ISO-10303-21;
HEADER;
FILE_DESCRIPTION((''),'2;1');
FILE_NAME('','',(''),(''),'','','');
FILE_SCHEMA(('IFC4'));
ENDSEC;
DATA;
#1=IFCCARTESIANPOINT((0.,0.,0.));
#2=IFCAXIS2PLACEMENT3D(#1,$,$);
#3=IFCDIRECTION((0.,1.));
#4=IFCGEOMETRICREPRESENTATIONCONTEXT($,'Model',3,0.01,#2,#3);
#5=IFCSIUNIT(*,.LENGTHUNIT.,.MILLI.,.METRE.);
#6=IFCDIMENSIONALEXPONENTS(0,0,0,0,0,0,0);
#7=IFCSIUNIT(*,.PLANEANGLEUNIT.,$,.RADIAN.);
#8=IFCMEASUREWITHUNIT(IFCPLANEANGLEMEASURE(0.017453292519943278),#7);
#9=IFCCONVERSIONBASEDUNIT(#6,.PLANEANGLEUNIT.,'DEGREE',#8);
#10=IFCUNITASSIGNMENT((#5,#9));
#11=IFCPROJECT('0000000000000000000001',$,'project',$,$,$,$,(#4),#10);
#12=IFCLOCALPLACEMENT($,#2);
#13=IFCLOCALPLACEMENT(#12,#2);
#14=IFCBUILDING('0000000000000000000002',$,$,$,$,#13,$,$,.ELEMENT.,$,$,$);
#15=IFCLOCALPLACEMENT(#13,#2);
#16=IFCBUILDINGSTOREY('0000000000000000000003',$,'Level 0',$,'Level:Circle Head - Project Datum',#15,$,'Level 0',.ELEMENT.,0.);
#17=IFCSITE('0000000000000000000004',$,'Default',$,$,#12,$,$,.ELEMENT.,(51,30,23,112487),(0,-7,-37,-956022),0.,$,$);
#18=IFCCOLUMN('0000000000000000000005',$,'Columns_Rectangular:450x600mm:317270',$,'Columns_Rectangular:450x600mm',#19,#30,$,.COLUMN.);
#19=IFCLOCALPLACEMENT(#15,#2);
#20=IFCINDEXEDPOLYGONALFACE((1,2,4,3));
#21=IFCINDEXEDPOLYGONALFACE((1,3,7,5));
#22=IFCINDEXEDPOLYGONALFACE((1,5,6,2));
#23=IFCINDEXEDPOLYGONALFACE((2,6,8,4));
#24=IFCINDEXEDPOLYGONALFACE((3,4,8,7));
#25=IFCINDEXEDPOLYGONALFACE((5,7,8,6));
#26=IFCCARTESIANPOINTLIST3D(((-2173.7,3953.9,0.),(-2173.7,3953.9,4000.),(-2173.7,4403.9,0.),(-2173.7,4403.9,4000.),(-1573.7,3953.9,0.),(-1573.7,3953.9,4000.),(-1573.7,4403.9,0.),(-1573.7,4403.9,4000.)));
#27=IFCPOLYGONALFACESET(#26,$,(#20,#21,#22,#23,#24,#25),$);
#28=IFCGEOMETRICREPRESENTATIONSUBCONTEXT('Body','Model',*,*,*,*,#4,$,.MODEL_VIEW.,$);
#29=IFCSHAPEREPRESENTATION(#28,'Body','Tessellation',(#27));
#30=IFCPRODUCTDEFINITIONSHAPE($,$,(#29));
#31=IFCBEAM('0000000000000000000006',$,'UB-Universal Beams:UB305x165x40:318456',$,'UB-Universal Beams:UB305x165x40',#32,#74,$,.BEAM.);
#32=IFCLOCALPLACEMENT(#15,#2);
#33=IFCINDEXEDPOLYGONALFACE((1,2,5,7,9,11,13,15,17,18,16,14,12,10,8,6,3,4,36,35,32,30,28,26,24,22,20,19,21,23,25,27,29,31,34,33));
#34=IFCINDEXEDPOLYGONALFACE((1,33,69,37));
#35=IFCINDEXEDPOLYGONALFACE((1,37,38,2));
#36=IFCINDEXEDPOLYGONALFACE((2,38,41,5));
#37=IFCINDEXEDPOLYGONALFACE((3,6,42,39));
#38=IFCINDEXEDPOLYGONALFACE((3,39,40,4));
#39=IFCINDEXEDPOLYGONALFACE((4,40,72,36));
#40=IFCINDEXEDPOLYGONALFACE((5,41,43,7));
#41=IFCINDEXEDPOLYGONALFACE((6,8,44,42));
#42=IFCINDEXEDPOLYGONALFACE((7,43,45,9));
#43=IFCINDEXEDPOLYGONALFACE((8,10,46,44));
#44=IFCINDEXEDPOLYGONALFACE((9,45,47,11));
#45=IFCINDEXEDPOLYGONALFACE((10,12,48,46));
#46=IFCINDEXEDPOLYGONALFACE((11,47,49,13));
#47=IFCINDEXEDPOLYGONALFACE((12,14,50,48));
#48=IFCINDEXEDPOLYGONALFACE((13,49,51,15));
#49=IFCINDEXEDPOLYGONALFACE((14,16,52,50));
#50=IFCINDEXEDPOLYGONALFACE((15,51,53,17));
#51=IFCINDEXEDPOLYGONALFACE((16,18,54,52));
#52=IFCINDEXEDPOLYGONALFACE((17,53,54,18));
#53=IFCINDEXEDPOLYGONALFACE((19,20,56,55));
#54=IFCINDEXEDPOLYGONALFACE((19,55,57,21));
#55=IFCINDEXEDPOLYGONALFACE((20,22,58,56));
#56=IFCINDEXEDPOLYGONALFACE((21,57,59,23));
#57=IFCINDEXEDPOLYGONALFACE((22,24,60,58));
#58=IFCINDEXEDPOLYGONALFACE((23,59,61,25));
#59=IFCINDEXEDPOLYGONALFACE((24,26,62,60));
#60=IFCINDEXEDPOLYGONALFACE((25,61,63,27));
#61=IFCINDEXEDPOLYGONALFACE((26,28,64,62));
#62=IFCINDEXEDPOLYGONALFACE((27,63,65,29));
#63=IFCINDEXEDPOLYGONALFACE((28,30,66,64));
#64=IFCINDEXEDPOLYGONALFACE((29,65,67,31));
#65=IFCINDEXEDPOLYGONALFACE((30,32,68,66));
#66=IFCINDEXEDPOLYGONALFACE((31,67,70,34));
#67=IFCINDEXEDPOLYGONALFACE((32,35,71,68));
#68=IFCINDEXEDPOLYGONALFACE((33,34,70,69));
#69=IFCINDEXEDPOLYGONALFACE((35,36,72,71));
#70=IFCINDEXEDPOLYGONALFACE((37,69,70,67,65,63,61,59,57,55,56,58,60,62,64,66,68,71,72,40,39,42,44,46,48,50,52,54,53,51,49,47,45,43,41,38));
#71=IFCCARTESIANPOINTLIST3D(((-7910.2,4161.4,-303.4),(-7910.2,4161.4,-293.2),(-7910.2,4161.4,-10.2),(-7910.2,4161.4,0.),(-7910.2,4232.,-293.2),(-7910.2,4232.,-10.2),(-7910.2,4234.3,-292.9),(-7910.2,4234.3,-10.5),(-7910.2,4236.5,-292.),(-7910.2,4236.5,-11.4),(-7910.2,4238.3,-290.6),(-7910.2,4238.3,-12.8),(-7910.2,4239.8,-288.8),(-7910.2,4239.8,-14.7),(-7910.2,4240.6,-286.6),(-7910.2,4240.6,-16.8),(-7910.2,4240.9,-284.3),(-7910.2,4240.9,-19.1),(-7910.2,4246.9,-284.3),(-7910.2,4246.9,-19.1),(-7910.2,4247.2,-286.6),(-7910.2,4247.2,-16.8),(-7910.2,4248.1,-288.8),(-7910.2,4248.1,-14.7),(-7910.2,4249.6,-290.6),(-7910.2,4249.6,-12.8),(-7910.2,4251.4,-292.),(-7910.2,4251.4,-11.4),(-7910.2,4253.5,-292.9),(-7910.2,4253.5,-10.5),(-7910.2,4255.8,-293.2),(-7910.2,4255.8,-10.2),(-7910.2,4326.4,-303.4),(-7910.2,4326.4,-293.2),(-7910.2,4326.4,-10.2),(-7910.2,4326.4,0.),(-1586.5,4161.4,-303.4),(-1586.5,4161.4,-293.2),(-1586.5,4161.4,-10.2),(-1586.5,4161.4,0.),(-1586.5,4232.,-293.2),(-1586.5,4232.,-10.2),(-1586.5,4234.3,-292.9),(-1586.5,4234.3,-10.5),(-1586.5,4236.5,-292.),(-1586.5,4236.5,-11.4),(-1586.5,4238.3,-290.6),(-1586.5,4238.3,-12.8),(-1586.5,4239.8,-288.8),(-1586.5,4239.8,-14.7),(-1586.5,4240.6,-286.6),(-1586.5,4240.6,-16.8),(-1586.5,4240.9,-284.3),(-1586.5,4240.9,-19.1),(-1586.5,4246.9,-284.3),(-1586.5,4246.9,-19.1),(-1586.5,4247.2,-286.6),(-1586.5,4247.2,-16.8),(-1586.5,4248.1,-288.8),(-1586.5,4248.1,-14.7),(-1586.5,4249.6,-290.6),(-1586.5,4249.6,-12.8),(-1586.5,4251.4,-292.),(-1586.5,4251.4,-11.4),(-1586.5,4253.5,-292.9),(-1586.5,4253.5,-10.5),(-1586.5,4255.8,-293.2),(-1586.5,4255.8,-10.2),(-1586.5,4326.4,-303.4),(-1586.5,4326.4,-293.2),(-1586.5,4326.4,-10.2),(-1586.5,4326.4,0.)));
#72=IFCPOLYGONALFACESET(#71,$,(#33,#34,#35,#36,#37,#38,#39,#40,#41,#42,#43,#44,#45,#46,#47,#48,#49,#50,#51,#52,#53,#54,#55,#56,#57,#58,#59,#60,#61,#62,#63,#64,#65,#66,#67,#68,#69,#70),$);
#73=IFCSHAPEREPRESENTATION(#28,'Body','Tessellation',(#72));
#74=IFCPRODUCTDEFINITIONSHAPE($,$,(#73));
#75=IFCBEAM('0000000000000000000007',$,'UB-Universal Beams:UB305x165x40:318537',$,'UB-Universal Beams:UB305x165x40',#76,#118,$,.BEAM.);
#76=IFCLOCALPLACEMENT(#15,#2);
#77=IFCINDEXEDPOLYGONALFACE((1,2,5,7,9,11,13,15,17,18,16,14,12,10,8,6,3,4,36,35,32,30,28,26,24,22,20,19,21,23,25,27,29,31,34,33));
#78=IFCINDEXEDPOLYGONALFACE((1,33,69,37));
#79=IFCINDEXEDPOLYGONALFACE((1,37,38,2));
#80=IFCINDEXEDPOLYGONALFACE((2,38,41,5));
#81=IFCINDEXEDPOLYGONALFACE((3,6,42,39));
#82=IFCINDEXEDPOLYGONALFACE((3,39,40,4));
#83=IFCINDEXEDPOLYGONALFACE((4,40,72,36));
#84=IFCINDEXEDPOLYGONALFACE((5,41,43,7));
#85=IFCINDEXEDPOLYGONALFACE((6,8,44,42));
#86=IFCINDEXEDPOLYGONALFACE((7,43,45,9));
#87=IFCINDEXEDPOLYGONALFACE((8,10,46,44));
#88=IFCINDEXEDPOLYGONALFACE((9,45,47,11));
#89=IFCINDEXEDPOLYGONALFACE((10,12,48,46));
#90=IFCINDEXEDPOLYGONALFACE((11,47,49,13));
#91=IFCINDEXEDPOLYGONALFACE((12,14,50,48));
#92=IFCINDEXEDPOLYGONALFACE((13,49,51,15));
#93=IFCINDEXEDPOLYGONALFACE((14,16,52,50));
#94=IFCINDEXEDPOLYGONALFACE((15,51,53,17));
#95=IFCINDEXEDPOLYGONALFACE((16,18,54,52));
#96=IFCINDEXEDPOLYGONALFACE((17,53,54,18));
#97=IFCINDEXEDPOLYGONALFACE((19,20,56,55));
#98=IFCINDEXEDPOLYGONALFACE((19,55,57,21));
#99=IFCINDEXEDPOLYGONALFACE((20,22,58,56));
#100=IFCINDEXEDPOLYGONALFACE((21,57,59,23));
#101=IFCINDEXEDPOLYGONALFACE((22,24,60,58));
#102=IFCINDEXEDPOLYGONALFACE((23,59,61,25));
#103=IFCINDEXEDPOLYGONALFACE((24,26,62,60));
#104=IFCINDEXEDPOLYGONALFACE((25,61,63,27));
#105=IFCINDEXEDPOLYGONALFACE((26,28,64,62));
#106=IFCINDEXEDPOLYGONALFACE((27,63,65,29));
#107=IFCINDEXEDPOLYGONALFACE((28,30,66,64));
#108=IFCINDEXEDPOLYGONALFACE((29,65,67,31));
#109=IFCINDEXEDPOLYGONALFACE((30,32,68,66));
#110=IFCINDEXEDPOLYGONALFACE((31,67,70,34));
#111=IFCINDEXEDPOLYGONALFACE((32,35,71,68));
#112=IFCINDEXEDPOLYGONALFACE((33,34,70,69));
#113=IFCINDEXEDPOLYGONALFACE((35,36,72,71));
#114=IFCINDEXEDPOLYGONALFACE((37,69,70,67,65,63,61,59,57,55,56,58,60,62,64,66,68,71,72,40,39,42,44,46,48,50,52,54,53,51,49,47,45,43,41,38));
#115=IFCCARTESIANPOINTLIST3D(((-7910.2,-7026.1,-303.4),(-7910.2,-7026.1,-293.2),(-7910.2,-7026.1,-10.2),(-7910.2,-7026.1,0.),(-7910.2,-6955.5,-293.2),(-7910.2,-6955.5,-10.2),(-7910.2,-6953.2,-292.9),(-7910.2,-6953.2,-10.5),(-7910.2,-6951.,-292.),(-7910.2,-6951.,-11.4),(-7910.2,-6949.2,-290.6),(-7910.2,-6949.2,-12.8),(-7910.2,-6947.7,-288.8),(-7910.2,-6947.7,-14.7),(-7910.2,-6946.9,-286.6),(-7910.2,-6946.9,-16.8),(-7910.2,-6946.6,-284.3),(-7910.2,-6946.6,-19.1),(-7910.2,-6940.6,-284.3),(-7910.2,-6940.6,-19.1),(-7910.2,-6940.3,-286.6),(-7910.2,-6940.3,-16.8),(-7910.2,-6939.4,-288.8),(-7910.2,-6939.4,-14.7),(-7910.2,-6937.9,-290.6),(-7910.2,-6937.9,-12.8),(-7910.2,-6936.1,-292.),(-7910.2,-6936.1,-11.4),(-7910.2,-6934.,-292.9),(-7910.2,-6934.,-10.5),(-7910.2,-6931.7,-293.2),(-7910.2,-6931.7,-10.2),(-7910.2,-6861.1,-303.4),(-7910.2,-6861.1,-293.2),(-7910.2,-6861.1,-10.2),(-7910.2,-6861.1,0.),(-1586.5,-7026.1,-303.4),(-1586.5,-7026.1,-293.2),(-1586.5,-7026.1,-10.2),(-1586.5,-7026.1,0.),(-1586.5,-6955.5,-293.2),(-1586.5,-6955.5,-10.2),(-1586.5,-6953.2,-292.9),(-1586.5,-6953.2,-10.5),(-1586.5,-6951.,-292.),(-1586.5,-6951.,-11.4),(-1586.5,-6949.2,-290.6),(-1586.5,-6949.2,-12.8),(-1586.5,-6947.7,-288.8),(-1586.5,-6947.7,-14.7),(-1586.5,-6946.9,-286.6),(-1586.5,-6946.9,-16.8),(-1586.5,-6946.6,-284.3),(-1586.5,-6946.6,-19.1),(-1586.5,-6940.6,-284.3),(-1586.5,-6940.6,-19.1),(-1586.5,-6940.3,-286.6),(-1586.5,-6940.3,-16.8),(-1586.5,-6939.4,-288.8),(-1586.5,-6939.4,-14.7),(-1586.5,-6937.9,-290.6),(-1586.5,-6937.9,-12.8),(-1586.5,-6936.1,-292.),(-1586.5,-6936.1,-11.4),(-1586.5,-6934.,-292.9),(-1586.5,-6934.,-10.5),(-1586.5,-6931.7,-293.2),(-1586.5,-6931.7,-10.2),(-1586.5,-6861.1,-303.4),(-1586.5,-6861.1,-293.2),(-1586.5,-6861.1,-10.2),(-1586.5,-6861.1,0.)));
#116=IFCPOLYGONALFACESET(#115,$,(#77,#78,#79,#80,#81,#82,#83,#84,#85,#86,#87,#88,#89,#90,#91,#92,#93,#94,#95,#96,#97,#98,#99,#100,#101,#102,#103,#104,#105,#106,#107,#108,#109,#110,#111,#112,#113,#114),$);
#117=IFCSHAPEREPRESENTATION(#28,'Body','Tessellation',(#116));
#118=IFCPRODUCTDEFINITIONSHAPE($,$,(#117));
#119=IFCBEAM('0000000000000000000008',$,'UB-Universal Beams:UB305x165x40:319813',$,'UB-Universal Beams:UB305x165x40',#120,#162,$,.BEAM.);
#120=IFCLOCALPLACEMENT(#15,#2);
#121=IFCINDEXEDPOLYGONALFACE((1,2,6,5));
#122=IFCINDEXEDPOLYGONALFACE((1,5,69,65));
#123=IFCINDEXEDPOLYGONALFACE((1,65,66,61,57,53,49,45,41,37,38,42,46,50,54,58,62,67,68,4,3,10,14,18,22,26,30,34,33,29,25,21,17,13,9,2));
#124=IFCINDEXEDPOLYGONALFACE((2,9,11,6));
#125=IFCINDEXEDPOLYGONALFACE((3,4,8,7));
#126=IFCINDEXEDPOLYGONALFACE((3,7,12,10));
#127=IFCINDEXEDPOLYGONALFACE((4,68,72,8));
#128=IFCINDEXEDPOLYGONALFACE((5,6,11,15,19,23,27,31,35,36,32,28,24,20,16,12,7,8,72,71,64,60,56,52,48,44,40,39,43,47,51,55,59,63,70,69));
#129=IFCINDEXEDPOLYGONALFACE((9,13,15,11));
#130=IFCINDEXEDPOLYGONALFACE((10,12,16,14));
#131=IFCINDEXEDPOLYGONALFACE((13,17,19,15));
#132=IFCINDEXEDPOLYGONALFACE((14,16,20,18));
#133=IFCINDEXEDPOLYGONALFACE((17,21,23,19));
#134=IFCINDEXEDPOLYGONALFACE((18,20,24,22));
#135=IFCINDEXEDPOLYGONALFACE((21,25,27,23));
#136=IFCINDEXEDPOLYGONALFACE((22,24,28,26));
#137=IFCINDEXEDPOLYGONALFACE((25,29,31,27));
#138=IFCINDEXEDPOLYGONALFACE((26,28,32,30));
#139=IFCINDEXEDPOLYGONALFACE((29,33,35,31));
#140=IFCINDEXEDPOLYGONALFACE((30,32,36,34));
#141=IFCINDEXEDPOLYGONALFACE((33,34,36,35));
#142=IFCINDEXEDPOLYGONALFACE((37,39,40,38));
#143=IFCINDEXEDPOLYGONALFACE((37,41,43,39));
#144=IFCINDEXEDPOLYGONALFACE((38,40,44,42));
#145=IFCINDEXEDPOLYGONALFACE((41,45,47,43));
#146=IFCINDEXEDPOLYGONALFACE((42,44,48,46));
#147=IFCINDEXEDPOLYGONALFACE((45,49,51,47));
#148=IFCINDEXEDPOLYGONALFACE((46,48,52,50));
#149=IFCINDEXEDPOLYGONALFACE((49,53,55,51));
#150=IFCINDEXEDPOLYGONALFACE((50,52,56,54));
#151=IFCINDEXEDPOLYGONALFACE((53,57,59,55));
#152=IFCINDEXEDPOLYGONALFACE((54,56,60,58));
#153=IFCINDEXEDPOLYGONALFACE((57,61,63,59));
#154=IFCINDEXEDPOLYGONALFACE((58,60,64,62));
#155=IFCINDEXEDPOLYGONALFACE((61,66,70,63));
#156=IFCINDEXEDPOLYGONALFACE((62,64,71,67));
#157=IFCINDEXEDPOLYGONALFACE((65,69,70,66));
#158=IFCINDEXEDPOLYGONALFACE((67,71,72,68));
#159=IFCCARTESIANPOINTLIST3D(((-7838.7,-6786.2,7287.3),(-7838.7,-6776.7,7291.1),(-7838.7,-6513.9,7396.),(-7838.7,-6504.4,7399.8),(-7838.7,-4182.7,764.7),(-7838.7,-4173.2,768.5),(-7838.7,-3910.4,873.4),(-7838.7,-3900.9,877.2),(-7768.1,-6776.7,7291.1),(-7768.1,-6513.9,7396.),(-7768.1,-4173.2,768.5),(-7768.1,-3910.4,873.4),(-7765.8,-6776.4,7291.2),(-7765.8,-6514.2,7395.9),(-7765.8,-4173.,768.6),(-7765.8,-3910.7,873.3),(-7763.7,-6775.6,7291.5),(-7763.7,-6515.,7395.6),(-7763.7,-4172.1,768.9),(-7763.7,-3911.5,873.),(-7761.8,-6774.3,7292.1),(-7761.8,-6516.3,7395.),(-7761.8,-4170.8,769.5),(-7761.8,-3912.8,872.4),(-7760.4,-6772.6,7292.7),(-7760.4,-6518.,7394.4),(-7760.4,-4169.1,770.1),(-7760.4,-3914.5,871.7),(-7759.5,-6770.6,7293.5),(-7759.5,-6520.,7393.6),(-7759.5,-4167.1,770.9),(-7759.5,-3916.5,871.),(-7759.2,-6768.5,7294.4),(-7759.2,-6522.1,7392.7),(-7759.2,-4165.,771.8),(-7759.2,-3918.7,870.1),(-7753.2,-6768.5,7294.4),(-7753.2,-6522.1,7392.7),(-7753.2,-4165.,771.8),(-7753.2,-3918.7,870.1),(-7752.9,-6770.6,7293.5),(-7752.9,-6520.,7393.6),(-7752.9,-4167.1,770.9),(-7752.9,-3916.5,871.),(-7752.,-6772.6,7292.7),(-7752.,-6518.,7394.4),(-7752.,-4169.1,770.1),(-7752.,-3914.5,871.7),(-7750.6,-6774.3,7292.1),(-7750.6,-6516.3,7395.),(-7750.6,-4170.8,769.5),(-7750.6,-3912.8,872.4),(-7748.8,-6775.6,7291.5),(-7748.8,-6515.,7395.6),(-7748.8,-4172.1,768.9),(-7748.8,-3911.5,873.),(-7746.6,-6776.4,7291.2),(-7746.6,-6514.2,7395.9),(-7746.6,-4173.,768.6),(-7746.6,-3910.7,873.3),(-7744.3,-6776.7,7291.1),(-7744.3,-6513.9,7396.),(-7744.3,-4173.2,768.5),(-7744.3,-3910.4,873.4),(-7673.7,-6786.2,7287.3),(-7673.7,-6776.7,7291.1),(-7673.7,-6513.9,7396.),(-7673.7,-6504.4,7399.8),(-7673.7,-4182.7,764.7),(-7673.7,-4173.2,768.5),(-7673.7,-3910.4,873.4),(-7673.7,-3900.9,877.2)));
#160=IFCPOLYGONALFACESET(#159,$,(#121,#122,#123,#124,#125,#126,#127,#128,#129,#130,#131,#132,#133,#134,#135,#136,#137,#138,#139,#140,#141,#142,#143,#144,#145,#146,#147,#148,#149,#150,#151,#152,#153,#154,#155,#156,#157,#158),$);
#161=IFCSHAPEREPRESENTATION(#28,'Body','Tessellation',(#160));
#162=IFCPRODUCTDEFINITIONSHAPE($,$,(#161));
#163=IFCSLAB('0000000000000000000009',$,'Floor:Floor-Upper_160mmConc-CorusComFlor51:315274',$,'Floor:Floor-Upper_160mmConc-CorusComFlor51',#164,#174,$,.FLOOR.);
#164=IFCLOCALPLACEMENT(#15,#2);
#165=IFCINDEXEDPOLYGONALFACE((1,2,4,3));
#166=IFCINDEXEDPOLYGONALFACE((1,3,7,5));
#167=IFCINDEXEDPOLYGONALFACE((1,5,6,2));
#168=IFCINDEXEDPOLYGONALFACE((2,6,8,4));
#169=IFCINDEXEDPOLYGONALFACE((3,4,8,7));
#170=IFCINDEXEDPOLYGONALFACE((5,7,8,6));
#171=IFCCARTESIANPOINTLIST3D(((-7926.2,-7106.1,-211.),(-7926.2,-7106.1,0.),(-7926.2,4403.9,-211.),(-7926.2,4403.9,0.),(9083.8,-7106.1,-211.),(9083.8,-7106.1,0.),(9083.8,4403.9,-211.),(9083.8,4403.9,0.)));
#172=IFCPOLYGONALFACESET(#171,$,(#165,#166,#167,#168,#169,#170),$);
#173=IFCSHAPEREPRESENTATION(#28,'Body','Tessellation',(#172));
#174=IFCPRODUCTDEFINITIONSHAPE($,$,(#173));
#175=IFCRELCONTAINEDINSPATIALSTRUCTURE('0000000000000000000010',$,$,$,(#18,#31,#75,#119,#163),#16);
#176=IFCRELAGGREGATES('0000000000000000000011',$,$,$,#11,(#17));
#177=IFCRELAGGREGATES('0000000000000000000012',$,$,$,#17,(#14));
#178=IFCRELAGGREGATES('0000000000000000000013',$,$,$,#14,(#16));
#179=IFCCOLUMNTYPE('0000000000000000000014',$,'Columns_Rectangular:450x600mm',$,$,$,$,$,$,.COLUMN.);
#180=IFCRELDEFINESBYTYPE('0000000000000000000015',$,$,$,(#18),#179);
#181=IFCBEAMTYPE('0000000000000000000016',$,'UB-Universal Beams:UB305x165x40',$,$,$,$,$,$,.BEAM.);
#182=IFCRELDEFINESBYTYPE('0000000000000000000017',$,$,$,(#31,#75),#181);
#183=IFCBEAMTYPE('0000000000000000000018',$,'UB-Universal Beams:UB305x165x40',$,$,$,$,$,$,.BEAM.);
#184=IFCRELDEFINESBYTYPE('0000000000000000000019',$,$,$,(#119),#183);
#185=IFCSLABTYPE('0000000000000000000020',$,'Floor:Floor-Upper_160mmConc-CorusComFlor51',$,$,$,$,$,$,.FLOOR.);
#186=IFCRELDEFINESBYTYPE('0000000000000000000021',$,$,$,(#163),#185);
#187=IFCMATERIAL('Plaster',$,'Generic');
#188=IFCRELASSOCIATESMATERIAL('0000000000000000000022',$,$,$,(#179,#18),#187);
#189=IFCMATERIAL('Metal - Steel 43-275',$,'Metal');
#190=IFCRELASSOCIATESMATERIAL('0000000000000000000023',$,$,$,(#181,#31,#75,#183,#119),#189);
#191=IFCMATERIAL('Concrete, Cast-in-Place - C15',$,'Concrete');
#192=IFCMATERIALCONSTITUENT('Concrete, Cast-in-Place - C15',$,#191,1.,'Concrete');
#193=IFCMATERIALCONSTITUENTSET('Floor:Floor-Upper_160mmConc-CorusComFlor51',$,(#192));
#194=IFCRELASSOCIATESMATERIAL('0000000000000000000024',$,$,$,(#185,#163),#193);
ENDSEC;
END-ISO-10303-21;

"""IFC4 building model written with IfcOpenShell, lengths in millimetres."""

from ifc_helpers import new_model, entity, si_unit, converted_unit, direction, frame, origin, place, context, subcontext, project, spatial, line, arc, indexed_curve, outline, extrude, source, transform, mapped, material, constituent, constituent_set, type_object, type_shapes, element, save


model = new_model("IFC4")

# Units and contexts
model_context = context("Model", 3, precision=0.01, world=origin(), true_north=direction((0.0, 1.0)))
body_context = subcontext(model_context, "Body", "Model", "MODEL_VIEW")
ifc_project = project(units=[si_unit("LENGTHUNIT", "METRE", prefix="MILLI"), converted_unit("PLANEANGLEUNIT", "DEGREE", entity("IfcPlaneAngleMeasure", 0.017453292519943278), si_unit("PLANEANGLEUNIT", "RADIAN"), dimensions=[0, 0, 0, 0, 0, 0, 0])], contexts=[model_context])

# Site, building, storey
site_placement = place(None, origin())
site = spatial("IfcSite", under=ifc_project, at=site_placement, Name="Default", CompositionType="ELEMENT", RefLatitude=(51, 30, 23, 112487), RefLongitude=(0, -7, -37, -956022), RefElevation=0.0)
building_placement = place(site_placement, origin())
building = spatial("IfcBuilding", under=site, at=building_placement, CompositionType="ELEMENT")
storey_placement = place(building_placement, origin())
storey = spatial("IfcBuildingStorey", under=building, at=storey_placement, Name="Level 0", ObjectType="Level:Circle Head - Project Datum", LongName="Level 0", CompositionType="ELEMENT", Elevation=0.0)

# Column
ifc_material_1 = material(Name="Metal - Steel 43-275", Category="Metal")
ifc_material_2 = material(Name="Plaster", Category="Generic")
column_type_1 = type_object("IfcColumnType", Name="Columns_Rectangular:450x600mm", PredefinedType="COLUMN", material=ifc_material_2)
shared_shape_1 = source(origin(), body_context, "Body", "SweptSolid", [
    extrude(outline(indexed_curve([(-300.0, -225.0), (300.0, -225.0), (300.0, 225.0), (-300.0, 225.0), (-300.0, -225.0)], self_intersect=False)), frame((-1873.7, 4178.9, 0.0), z_axis=(0.0, 0.0, 1.0), x_axis=(-1.0, 0.0, 0.0)), (0.0, 0.0, 1.0), 4000.0),
])
type_shapes(column_type_1, [shared_shape_1])
column_placement = place(storey_placement, origin())
element("IfcColumn", 1, at=column_placement, inside=storey, type_object=column_type_1, material=ifc_material_2, Name="Columns_Rectangular:450x600mm:317270", ObjectType="Columns_Rectangular:450x600mm", PredefinedType="COLUMN", context=body_context, shape_type="MappedRepresentation", body=[
    mapped(shared_shape_1, transform((0.0, 0.0, 0.0), scale=1.0)),
])

# Beams
beam_type_1 = type_object("IfcBeamType", Name="UB-Universal Beams:UB305x165x40", PredefinedType="BEAM", material=ifc_material_1)
shared_shape_2 = source(origin(), body_context, "Body", "SweptSolid", [
    extrude(outline(indexed_curve([(-82.5, -141.5), (-82.5, -151.7), (82.5, -151.7), (82.5, -141.5), (11.9, -141.5), (5.6, -138.9), (3.0, -132.6), (3.0, 132.6), (5.6, 138.9), (11.9, 141.5), (82.5, 141.5), (82.5, 151.7), (-82.5, 151.7), (-82.5, 141.5), (-11.9, 141.5), (-5.6, 138.9), (-3.0, 132.6), (-3.0, -132.6), (-5.6, -138.9), (-11.9, -141.5)], segments=[line(1, 2, 3, 4, 5), arc(5, 6, 7), line(7, 8), arc(8, 9, 10), line(10, 11, 12, 13, 14, 15), arc(15, 16, 17), line(17, 18), arc(18, 19, 20), line(20, 1)], self_intersect=False)), frame((-3191.9, 0.0, 0.0), z_axis=(-1.0, 0.0, 0.0), x_axis=(0.0, -1.0, 0.0)), (0.0, 0.0, -1.0), 6323.7),
])
type_shapes(beam_type_1, [shared_shape_2])
for number, where, name in (
    (2, (-4718.2, 4243.9, -151.7), "UB-Universal Beams:UB305x165x40:318456"),
    (3, (-4718.2, -6943.6, -151.7), "UB-Universal Beams:UB305x165x40:318537"),
):
    element("IfcBeam", number, at=place(storey_placement, frame(where)), inside=storey, type_object=beam_type_1, material=ifc_material_1, Name=name, ObjectType="UB-Universal Beams:UB305x165x40", PredefinedType="BEAM", context=body_context, shape_type="MappedRepresentation", body=[
        mapped(shared_shape_2, transform((0.0, 0.0, 0.0), scale=1.0)),
    ])
beam_type_2 = type_object("IfcBeamType", Name="UB-Universal Beams:UB305x165x40", PredefinedType="BEAM", material=ifc_material_1)
shared_shape_3 = source(origin(), body_context, "Body", "SweptSolid", [
    extrude(outline(indexed_curve([(-82.5, -141.5), (-82.5, -151.7), (82.5, -151.7), (82.5, -141.5), (11.9, -141.5), (5.6, -138.9), (3.0, -132.6), (3.0, 132.6), (5.6, 138.9), (11.9, 141.5), (82.5, 141.5), (82.5, 151.7), (-82.5, 151.7), (-82.5, 141.5), (-11.9, 141.5), (-5.6, 138.9), (-3.0, 132.6), (-3.0, -132.6), (-5.6, -138.9), (-11.9, -141.5)], segments=[line(1, 2, 3, 4, 5), arc(5, 6, 7), line(7, 8), arc(8, 9, 10), line(10, 11, 12, 13, 14, 15), arc(15, 16, 17), line(17, 18), arc(18, 19, 20), line(20, 1)], self_intersect=False)), frame((-3122.3, 0.0, 0.0), z_axis=(-1.0, 0.0, 0.0), x_axis=(0.0, -1.0, 0.0)), (0.0, 0.0, -1.0), 7023.0),
])
type_shapes(beam_type_2, [shared_shape_3])
beam_placement = place(storey_placement, frame((-7756.2, -5487.9, 4443.8), z_axis=(0.0, 0.928749, 0.370708), x_axis=(0.0, 0.370708, -0.928749)))
element("IfcBeam", 4, at=beam_placement, inside=storey, type_object=beam_type_2, material=ifc_material_1, Name="UB-Universal Beams:UB305x165x40:319813", ObjectType="UB-Universal Beams:UB305x165x40", PredefinedType="BEAM", context=body_context, shape_type="MappedRepresentation", body=[
    mapped(shared_shape_3, transform((0.0, 0.0, 0.0), scale=1.0)),
])

# Slab
ifc_material_3 = material(Name="Concrete, Cast-in-Place - C15", Category="Concrete")
ifc_constituent_1 = constituent(ifc_material_3, Name="Concrete, Cast-in-Place - C15", Category="Concrete", fraction=1.0)
ifc_constituent_set_1 = constituent_set(constituents=[ifc_constituent_1], Name="Floor:Floor-Upper_160mmConc-CorusComFlor51")
slab_type = type_object("IfcSlabType", Name="Floor:Floor-Upper_160mmConc-CorusComFlor51", PredefinedType="FLOOR", material=ifc_constituent_set_1)
slab_placement = place(storey_placement, origin())
element("IfcSlab", 5, at=slab_placement, inside=storey, type_object=slab_type, material=ifc_constituent_set_1, Name="Floor:Floor-Upper_160mmConc-CorusComFlor51:315274", ObjectType="Floor:Floor-Upper_160mmConc-CorusComFlor51", PredefinedType="FLOOR", context=body_context, shape_type="SweptSolid", body=[
    extrude(outline(indexed_curve([(-5755.0, -8505.0), (5755.0, -8505.0), (5755.0, 8505.0), (-5755.0, 8505.0), (-5755.0, -8505.0)], self_intersect=False)), frame((578.8, -1351.1, 0.0), z_axis=(0.0, 0.0, -1.0), x_axis=(0.0, 1.0, 0.0)), (0.0, 0.0, 1.0), 211.0),
])

save(model, "model.ifc")
